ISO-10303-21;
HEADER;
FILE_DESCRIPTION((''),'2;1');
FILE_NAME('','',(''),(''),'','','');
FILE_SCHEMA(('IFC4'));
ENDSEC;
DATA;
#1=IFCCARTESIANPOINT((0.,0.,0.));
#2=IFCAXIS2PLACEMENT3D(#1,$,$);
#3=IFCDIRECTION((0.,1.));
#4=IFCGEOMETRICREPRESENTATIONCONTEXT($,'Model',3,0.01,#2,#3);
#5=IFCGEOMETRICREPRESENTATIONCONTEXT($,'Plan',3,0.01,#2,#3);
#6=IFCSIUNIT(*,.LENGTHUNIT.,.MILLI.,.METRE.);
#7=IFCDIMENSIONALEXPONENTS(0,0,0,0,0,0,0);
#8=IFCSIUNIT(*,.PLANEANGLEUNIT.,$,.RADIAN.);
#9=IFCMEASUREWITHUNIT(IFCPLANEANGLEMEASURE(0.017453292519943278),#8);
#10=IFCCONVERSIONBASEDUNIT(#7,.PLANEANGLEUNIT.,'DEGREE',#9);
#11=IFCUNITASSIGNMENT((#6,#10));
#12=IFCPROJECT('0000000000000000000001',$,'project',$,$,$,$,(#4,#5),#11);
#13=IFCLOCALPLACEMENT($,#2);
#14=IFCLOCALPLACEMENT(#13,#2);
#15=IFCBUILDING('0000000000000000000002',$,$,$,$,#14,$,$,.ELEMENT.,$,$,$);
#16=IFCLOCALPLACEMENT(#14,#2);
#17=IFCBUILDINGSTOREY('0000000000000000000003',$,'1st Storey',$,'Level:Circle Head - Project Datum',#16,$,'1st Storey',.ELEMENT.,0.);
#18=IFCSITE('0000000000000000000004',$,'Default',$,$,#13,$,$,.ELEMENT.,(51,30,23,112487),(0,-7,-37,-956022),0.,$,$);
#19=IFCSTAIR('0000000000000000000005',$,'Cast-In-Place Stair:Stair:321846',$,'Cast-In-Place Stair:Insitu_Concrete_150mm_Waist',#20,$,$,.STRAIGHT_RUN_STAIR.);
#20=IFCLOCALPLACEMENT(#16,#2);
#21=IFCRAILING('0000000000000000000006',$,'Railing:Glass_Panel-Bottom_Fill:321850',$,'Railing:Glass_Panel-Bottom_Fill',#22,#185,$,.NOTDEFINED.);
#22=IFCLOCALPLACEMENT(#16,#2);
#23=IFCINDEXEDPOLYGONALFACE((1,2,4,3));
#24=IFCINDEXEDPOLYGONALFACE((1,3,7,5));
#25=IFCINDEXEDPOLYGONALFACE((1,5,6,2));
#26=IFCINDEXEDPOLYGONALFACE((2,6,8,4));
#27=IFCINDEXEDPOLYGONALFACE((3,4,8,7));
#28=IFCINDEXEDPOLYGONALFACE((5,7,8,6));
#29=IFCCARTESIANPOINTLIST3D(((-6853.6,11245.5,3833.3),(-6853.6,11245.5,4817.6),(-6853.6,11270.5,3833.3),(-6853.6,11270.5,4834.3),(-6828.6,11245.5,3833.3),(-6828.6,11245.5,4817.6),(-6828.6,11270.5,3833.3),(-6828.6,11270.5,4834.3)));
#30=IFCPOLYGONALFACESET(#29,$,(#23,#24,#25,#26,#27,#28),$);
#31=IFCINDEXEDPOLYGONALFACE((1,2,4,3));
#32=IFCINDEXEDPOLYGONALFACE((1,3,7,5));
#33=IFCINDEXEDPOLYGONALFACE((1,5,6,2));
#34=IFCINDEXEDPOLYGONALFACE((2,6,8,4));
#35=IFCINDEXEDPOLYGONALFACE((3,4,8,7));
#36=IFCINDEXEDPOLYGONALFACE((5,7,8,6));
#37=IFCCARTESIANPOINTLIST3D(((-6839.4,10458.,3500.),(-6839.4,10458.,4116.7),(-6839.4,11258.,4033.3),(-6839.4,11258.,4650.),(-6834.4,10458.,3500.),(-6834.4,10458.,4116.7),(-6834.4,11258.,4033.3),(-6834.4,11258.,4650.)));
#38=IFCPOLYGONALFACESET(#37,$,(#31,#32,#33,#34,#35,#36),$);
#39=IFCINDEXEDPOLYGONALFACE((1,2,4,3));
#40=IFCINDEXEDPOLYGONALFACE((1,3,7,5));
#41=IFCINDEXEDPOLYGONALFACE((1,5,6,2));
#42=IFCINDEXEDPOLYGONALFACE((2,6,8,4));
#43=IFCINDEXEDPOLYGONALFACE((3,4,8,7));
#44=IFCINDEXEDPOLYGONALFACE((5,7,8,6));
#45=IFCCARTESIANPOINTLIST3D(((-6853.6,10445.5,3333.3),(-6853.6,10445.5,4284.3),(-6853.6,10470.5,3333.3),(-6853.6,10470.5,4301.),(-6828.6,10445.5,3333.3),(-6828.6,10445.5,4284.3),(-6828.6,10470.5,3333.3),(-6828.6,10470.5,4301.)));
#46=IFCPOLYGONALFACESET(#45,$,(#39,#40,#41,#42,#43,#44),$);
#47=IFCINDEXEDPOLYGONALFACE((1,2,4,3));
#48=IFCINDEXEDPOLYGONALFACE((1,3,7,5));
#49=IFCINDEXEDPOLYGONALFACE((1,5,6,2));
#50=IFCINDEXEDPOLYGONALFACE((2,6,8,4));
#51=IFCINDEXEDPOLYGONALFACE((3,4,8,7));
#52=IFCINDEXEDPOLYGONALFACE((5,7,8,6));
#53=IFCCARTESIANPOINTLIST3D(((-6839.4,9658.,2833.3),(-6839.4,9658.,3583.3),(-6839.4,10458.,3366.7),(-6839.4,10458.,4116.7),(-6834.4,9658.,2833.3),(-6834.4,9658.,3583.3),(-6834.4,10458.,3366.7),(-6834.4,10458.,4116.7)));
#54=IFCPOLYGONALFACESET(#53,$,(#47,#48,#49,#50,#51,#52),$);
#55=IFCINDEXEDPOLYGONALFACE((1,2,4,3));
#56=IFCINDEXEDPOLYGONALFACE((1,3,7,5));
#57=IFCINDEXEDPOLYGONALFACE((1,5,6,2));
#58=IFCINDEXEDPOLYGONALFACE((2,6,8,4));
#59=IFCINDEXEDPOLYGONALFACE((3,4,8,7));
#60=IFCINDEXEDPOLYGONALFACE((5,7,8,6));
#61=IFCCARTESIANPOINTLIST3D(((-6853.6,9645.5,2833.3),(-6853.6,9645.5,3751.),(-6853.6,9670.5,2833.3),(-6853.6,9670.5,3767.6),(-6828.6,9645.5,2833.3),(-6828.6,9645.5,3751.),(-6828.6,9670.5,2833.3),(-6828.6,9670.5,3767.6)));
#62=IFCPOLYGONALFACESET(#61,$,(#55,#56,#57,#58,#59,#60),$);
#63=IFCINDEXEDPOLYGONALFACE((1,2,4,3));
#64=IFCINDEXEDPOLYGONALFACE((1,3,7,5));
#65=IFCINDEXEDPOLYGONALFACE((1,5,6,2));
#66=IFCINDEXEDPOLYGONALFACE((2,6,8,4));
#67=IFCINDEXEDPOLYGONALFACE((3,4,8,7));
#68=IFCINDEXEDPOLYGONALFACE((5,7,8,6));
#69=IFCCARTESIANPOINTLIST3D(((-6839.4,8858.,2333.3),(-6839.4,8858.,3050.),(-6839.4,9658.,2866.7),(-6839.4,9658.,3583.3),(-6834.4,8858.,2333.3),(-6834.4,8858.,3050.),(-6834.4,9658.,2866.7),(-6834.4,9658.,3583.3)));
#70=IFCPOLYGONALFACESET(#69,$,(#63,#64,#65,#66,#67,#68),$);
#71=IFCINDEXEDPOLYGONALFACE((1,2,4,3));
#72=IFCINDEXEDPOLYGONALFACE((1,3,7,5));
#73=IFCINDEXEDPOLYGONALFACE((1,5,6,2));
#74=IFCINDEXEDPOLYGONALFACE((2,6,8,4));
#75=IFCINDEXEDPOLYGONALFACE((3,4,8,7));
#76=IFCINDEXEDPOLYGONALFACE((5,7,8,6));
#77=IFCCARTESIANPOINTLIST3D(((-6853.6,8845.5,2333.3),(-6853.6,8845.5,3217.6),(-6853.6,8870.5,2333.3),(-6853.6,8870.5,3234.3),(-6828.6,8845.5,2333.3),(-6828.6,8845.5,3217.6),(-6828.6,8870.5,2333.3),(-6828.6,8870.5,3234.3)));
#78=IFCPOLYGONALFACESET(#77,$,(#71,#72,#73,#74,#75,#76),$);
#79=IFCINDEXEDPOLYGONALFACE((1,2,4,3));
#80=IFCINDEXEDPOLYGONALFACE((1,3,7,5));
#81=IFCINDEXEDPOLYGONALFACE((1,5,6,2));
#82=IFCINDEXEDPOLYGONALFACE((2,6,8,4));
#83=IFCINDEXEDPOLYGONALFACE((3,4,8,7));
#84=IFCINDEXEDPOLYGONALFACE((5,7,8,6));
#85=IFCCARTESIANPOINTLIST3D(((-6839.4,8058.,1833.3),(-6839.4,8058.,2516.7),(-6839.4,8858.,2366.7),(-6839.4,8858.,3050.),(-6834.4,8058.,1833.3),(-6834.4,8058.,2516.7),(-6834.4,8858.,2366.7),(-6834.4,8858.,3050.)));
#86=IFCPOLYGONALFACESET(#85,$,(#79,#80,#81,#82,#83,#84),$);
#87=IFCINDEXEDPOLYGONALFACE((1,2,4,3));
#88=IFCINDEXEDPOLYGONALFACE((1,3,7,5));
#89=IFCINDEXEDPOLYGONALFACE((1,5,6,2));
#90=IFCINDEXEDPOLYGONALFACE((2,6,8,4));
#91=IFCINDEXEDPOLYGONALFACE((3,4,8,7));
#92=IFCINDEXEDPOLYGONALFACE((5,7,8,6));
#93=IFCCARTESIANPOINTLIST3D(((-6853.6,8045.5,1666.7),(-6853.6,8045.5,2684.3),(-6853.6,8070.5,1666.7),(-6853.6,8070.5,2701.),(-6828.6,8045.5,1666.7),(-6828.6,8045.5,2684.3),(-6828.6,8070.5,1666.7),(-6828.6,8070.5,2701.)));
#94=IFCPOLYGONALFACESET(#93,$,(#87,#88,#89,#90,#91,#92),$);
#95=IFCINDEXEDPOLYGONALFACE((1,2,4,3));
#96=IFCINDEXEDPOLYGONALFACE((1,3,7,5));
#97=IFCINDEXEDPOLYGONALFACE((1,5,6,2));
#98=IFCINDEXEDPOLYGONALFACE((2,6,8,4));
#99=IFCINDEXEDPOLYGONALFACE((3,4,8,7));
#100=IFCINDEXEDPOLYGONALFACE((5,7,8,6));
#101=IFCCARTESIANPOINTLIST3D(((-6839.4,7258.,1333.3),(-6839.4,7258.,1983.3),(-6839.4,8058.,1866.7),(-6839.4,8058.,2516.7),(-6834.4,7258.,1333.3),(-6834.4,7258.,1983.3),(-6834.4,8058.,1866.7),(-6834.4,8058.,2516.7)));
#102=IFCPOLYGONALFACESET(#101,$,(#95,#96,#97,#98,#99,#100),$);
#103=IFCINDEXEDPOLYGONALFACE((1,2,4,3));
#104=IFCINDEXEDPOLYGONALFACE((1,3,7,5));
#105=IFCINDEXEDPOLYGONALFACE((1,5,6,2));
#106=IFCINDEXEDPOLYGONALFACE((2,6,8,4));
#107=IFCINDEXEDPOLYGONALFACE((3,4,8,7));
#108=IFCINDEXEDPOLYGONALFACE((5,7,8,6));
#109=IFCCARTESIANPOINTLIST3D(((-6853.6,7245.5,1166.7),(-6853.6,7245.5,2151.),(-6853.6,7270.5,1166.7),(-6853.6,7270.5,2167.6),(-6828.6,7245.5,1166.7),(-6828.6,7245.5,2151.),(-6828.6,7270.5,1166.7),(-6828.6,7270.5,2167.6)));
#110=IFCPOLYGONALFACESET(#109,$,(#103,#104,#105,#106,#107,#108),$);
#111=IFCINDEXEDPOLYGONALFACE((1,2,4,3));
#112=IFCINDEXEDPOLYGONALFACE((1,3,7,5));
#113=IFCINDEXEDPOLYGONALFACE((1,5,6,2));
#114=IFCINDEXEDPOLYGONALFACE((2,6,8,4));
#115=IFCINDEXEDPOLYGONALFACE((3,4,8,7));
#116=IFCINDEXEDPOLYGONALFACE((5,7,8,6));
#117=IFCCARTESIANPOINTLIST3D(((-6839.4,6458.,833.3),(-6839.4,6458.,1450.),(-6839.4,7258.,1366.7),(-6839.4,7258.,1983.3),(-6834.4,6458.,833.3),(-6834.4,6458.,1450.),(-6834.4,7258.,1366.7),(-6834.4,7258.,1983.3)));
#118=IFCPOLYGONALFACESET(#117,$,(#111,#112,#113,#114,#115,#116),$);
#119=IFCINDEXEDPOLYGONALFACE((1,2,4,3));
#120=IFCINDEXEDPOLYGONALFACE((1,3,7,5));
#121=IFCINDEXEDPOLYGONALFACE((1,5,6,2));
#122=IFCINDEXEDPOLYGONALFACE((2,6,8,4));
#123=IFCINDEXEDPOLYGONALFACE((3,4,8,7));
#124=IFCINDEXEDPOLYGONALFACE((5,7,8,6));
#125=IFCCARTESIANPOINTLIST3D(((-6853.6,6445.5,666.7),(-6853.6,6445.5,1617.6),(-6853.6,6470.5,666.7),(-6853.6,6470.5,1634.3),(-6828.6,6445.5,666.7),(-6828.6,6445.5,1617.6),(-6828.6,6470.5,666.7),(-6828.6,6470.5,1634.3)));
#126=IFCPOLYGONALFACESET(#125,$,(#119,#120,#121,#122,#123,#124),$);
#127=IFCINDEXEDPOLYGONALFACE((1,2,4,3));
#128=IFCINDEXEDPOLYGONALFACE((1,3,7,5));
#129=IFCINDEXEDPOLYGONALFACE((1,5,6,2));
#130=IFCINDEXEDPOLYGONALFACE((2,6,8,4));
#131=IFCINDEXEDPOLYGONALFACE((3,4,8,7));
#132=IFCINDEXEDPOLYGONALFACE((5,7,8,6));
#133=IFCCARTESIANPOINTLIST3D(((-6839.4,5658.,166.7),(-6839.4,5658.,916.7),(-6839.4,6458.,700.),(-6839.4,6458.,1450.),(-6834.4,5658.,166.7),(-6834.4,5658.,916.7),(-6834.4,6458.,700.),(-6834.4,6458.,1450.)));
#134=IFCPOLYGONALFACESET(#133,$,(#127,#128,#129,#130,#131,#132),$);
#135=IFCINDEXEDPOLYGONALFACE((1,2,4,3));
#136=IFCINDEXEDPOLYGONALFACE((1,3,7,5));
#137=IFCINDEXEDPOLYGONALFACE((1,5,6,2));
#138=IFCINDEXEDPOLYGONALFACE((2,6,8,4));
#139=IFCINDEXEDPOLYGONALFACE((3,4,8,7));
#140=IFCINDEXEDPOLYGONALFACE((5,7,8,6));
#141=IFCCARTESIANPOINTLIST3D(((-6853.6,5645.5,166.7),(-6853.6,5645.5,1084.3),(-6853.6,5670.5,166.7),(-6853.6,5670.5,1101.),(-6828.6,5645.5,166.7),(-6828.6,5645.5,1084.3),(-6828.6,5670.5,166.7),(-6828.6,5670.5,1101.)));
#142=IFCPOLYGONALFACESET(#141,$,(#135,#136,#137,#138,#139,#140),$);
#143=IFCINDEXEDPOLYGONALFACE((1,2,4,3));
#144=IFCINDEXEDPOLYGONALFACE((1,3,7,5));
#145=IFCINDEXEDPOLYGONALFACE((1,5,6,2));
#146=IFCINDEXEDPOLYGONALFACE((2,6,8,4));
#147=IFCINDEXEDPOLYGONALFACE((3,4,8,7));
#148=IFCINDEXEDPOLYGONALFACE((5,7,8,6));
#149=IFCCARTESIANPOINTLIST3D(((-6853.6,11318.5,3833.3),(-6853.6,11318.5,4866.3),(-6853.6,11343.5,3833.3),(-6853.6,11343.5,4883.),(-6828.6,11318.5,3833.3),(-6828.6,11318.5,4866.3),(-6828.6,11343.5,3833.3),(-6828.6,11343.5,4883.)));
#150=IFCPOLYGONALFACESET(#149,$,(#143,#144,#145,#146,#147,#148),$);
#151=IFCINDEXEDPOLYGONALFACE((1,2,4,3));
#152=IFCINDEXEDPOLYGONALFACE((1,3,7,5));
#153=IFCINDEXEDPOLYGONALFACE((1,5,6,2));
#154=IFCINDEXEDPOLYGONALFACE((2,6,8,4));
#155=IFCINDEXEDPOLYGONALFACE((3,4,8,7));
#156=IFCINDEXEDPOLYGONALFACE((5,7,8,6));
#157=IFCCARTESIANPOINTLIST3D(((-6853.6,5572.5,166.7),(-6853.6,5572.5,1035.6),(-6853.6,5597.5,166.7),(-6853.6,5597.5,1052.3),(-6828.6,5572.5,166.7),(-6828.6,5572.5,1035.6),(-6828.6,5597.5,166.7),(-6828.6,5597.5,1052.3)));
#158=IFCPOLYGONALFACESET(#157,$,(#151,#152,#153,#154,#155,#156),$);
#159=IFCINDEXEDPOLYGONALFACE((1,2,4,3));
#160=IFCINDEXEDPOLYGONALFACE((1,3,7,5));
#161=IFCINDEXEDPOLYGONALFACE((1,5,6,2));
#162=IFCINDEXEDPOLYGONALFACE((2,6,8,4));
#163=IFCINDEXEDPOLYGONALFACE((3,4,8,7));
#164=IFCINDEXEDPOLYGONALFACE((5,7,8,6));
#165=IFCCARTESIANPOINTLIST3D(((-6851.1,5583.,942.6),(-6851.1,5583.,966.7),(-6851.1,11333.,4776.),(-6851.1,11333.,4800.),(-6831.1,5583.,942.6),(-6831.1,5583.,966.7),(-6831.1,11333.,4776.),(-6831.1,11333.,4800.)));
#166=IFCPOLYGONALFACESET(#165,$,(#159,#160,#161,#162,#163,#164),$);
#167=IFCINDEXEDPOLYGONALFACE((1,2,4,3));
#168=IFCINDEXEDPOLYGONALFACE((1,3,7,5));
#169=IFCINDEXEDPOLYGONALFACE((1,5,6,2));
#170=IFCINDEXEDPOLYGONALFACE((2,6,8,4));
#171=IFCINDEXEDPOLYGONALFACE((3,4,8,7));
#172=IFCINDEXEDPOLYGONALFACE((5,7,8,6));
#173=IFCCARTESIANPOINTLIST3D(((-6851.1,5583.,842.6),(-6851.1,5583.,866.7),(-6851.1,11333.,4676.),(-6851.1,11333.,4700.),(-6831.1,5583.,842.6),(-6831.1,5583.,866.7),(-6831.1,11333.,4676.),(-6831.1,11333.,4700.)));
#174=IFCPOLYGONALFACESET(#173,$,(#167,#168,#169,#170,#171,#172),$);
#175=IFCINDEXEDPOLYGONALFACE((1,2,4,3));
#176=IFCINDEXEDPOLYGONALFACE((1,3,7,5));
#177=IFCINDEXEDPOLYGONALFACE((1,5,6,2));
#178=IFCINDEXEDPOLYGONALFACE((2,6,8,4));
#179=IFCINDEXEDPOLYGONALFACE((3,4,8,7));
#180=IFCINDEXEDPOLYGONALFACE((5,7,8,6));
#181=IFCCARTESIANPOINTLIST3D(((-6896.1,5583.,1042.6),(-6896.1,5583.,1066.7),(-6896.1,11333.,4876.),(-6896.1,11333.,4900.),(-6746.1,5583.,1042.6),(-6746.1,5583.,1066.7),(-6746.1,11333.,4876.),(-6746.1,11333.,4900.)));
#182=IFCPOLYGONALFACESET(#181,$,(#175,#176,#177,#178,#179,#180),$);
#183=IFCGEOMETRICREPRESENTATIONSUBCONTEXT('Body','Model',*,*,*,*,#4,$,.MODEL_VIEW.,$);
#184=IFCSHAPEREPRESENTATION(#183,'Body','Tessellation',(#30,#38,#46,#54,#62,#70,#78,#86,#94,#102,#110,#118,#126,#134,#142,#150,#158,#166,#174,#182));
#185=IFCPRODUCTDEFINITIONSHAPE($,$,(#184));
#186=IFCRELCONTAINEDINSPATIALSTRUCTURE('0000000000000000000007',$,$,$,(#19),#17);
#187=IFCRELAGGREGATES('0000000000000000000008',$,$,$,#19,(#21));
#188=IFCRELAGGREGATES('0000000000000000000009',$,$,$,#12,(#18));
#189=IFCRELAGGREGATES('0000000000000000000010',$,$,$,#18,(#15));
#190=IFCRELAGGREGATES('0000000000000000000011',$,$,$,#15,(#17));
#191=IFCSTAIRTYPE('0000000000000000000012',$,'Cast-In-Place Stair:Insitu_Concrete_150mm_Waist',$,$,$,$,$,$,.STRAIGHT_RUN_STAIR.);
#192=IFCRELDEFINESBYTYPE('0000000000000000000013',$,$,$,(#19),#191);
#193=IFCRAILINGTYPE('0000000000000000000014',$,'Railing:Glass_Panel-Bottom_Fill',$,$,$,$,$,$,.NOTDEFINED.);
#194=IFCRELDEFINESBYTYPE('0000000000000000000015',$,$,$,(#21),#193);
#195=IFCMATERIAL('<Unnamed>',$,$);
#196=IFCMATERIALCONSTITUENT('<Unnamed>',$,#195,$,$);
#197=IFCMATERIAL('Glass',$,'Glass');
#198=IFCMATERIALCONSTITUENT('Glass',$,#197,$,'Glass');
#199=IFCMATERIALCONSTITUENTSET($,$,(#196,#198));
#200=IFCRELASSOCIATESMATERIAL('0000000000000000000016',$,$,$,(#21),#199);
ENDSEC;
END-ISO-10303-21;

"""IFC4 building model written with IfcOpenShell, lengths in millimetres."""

from ifc_helpers import new_model, entity, si_unit, converted_unit, direction, frame, origin, place, context, subcontext, project, spatial, indexed_curve, outline, extrude, material, constituent, constituent_set, type_object, element, aggregate, save


model = new_model("IFC4")

# Units and contexts
model_context = context("Model", 3, precision=0.01, world=origin(), true_north=direction((0.0, 1.0)))
plan_context = context("Plan", 3, precision=0.01, world=origin(), true_north=direction((0.0, 1.0)))
body_context = subcontext(model_context, "Body", "Model", "MODEL_VIEW")
ifc_project = project(units=[si_unit("LENGTHUNIT", "METRE", prefix="MILLI"), converted_unit("PLANEANGLEUNIT", "DEGREE", entity("IfcPlaneAngleMeasure", 0.017453292519943278), si_unit("PLANEANGLEUNIT", "RADIAN"), dimensions=[0, 0, 0, 0, 0, 0, 0])], contexts=[model_context, plan_context])

# Site, building, storey
site_placement = place(None, origin())
site = spatial("IfcSite", under=ifc_project, at=site_placement, Name="Default", CompositionType="ELEMENT", RefLatitude=(51, 30, 23, 112487), RefLongitude=(0, -7, -37, -956022), RefElevation=0.0)
building_placement = place(site_placement, origin())
building = spatial("IfcBuilding", under=site, at=building_placement, CompositionType="ELEMENT")
storey_placement = place(building_placement, origin())
storey = spatial("IfcBuildingStorey", under=building, at=storey_placement, Name="1st Storey", ObjectType="Level:Circle Head - Project Datum", LongName="1st Storey", CompositionType="ELEMENT", Elevation=0.0)

# Shared definitions
ifc_material_1 = material(Name="<Unnamed>")

# Stair, railing
stair_type_1 = type_object("IfcStairType", Name="Cast-In-Place Stair:Insitu_Concrete_150mm_Waist", PredefinedType="STRAIGHT_RUN_STAIR")
stair_1_placement = place(storey_placement, origin())
stair_1 = element("IfcStair", 1, at=stair_1_placement, inside=storey, type_object=stair_type_1, Name="Cast-In-Place Stair:Stair:321846", ObjectType="Cast-In-Place Stair:Insitu_Concrete_150mm_Waist", PredefinedType="STRAIGHT_RUN_STAIR")
ifc_constituent_1 = constituent(ifc_material_1, Name="<Unnamed>")
ifc_material_2 = material(Name="Glass", Category="Glass")
ifc_constituent_2 = constituent(ifc_material_2, Name="Glass", Category="Glass")
ifc_constituent_set_1 = constituent_set(constituents=[ifc_constituent_1, ifc_constituent_2])
railing_type = type_object("IfcRailingType", Name="Railing:Glass_Panel-Bottom_Fill", PredefinedType="NOTDEFINED")
railing_1_placement = place(stair_1_placement, frame((-6896.1, 5572.5, 166.7)))
railing_1 = element("IfcRailing", 2, at=railing_1_placement, type_object=railing_type, material=ifc_constituent_set_1, Name="Railing:Glass_Panel-Bottom_Fill:321850", ObjectType="Railing:Glass_Panel-Bottom_Fill", PredefinedType="NOTDEFINED", context=body_context, shape_type="SweptSolid", body=[
    extrude(outline(indexed_curve([(-12.5, -496.3), (12.5, -496.3), (12.5, 504.6), (-12.5, 488.0), (-12.5, -496.3)], self_intersect=False)), frame((42.5, 5685.5, 4163.0), z_axis=(1.0, 0.0, 0.0), x_axis=(0.0, 1.0, 0.0)), (0.0, 0.0, 1.0), 25.0),
    extrude(outline(indexed_curve([(-41.7, -400.0), (575.0, -400.0), (41.7, 400.0), (-575.0, 400.0), (-41.7, -400.0)], self_intersect=False)), frame((56.7, 5285.5, 3908.3), z_axis=(1.0, 0.0, 0.0), x_axis=(0.0, 0.0, -1.0)), (0.0, 0.0, 1.0), 5.0),
    extrude(outline(indexed_curve([(-12.5, -479.6), (12.5, -479.6), (12.5, 488.0), (-12.5, 471.3), (-12.5, -479.6)], self_intersect=False)), frame((42.5, 4885.5, 3646.3), z_axis=(1.0, 0.0, 0.0), x_axis=(0.0, 1.0, 0.0)), (0.0, 0.0, 1.0), 25.0),
    extrude(outline(indexed_curve([(-108.3, -400.0), (641.7, -400.0), (108.3, 400.0), (-641.7, 400.0), (-108.3, -400.0)], self_intersect=False)), frame((56.7, 4485.5, 3308.3), z_axis=(1.0, 0.0, 0.0), x_axis=(0.0, 0.0, -1.0)), (0.0, 0.0, 1.0), 5.0),
    extrude(outline(indexed_curve([(-12.5, -463.0), (12.5, -463.0), (12.5, 471.3), (-12.5, 454.6), (-12.5, -463.0)], self_intersect=False)), frame((42.5, 4085.5, 3129.6), z_axis=(1.0, 0.0, 0.0), x_axis=(0.0, 1.0, 0.0)), (0.0, 0.0, 1.0), 25.0),
    extrude(outline(indexed_curve([(-91.7, -400.0), (625.0, -400.0), (91.7, 400.0), (-625.0, 400.0), (-91.7, -400.0)], self_intersect=False)), frame((56.7, 3685.5, 2791.7), z_axis=(1.0, 0.0, 0.0), x_axis=(0.0, 0.0, -1.0)), (0.0, 0.0, 1.0), 5.0),
    extrude(outline(indexed_curve([(-12.5, -446.3), (12.5, -446.3), (12.5, 454.6), (-12.5, 438.0), (-12.5, -446.3)], self_intersect=False)), frame((42.5, 3285.5, 2613.0), z_axis=(1.0, 0.0, 0.0), x_axis=(0.0, 1.0, 0.0)), (0.0, 0.0, 1.0), 25.0),
    extrude(outline(indexed_curve([(-75.0, -400.0), (608.3, -400.0), (75.0, 400.0), (-608.3, 400.0), (-75.0, -400.0)], self_intersect=False)), frame((56.7, 2885.5, 2275.0), z_axis=(1.0, 0.0, 0.0), x_axis=(0.0, 0.0, -1.0)), (0.0, 0.0, 1.0), 5.0),
    extrude(outline(indexed_curve([(-12.5, -513.0), (12.5, -513.0), (12.5, 521.3), (-12.5, 504.6), (-12.5, -513.0)], self_intersect=False)), frame((42.5, 2485.5, 2013.0), z_axis=(1.0, 0.0, 0.0), x_axis=(0.0, 1.0, 0.0)), (0.0, 0.0, 1.0), 25.0),
    extrude(outline(indexed_curve([(-58.3, -400.0), (591.7, -400.0), (58.3, 400.0), (-591.7, 400.0), (-58.3, -400.0)], self_intersect=False)), frame((56.7, 2085.5, 1758.3), z_axis=(1.0, 0.0, 0.0), x_axis=(0.0, 0.0, -1.0)), (0.0, 0.0, 1.0), 5.0),
    extrude(outline(indexed_curve([(-12.5, -496.3), (12.5, -496.3), (12.5, 504.6), (-12.5, 488.0), (-12.5, -496.3)], self_intersect=False)), frame((42.5, 1685.5, 1496.3), z_axis=(1.0, 0.0, 0.0), x_axis=(0.0, 1.0, 0.0)), (0.0, 0.0, 1.0), 25.0),
    extrude(outline(indexed_curve([(-41.7, -400.0), (575.0, -400.0), (41.7, 400.0), (-575.0, 400.0), (-41.7, -400.0)], self_intersect=False)), frame((56.7, 1285.5, 1241.7), z_axis=(1.0, 0.0, 0.0), x_axis=(0.0, 0.0, -1.0)), (0.0, 0.0, 1.0), 5.0),
    extrude(outline(indexed_curve([(-12.5, -479.6), (12.5, -479.6), (12.5, 488.0), (-12.5, 471.3), (-12.5, -479.6)], self_intersect=False)), frame((42.5, 885.5, 979.6), z_axis=(1.0, 0.0, 0.0), x_axis=(0.0, 1.0, 0.0)), (0.0, 0.0, 1.0), 25.0),
    extrude(outline(indexed_curve([(-108.3, -400.0), (641.7, -400.0), (108.3, 400.0), (-641.7, 400.0), (-108.3, -400.0)], self_intersect=False)), frame((56.7, 485.5, 641.7), z_axis=(1.0, 0.0, 0.0), x_axis=(0.0, 0.0, -1.0)), (0.0, 0.0, 1.0), 5.0),
    extrude(outline(indexed_curve([(-12.5, -463.0), (12.5, -463.0), (12.5, 471.3), (-12.5, 454.6), (-12.5, -463.0)], self_intersect=False)), frame((42.5, 85.5, 463.0), z_axis=(1.0, 0.0, 0.0), x_axis=(0.0, 1.0, 0.0)), (0.0, 0.0, 1.0), 25.0),
    extrude(outline(indexed_curve([(-12.5, -520.6), (12.5, -520.6), (12.5, 529.0), (-12.5, 512.3), (-12.5, -520.6)], self_intersect=False)), frame((42.5, 5758.5, 4187.3), z_axis=(1.0, 0.0, 0.0), x_axis=(0.0, 1.0, 0.0)), (0.0, 0.0, 1.0), 25.0),
    extrude(outline(indexed_curve([(-12.5, -438.6), (12.5, -438.6), (12.5, 447.0), (-12.5, 430.3), (-12.5, -438.6)], self_intersect=False)), frame((42.5, 12.5, 438.6), z_axis=(1.0, 0.0, 0.0), x_axis=(0.0, 1.0, 0.0)), (0.0, 0.0, 1.0), 25.0),
    extrude(outline(indexed_curve([(-3462.0, -10.0), (3448.7, -10.0), (3462.0, 10.0), (-3448.7, 10.0), (-3462.0, -10.0)], self_intersect=False)), frame((45.0, 2885.5, 2704.6), z_axis=(1.0, 0.0, 0.0), x_axis=(0.0, 0.83205, 0.5547)), (0.0, 0.0, 1.0), 20.0),
    extrude(outline(indexed_curve([(-3462.0, -10.0), (3448.7, -10.0), (3462.0, 10.0), (-3448.7, 10.0), (-3462.0, -10.0)], self_intersect=False)), frame((45.0, 2885.5, 2604.6), z_axis=(1.0, 0.0, 0.0), x_axis=(0.0, 0.83205, 0.5547)), (0.0, 0.0, 1.0), 20.0),
    extrude(outline(indexed_curve([(-3462.0, -10.0), (3448.7, -10.0), (3462.0, 10.0), (-3448.7, 10.0), (-3462.0, -10.0)], self_intersect=False)), frame((0.0, 2885.5, 2804.6), z_axis=(1.0, 0.0, 0.0), x_axis=(0.0, 0.83205, 0.5547)), (0.0, 0.0, 1.0), 150.0),
])
aggregate(stair_1, [railing_1])

save(model, "model.ifc")
